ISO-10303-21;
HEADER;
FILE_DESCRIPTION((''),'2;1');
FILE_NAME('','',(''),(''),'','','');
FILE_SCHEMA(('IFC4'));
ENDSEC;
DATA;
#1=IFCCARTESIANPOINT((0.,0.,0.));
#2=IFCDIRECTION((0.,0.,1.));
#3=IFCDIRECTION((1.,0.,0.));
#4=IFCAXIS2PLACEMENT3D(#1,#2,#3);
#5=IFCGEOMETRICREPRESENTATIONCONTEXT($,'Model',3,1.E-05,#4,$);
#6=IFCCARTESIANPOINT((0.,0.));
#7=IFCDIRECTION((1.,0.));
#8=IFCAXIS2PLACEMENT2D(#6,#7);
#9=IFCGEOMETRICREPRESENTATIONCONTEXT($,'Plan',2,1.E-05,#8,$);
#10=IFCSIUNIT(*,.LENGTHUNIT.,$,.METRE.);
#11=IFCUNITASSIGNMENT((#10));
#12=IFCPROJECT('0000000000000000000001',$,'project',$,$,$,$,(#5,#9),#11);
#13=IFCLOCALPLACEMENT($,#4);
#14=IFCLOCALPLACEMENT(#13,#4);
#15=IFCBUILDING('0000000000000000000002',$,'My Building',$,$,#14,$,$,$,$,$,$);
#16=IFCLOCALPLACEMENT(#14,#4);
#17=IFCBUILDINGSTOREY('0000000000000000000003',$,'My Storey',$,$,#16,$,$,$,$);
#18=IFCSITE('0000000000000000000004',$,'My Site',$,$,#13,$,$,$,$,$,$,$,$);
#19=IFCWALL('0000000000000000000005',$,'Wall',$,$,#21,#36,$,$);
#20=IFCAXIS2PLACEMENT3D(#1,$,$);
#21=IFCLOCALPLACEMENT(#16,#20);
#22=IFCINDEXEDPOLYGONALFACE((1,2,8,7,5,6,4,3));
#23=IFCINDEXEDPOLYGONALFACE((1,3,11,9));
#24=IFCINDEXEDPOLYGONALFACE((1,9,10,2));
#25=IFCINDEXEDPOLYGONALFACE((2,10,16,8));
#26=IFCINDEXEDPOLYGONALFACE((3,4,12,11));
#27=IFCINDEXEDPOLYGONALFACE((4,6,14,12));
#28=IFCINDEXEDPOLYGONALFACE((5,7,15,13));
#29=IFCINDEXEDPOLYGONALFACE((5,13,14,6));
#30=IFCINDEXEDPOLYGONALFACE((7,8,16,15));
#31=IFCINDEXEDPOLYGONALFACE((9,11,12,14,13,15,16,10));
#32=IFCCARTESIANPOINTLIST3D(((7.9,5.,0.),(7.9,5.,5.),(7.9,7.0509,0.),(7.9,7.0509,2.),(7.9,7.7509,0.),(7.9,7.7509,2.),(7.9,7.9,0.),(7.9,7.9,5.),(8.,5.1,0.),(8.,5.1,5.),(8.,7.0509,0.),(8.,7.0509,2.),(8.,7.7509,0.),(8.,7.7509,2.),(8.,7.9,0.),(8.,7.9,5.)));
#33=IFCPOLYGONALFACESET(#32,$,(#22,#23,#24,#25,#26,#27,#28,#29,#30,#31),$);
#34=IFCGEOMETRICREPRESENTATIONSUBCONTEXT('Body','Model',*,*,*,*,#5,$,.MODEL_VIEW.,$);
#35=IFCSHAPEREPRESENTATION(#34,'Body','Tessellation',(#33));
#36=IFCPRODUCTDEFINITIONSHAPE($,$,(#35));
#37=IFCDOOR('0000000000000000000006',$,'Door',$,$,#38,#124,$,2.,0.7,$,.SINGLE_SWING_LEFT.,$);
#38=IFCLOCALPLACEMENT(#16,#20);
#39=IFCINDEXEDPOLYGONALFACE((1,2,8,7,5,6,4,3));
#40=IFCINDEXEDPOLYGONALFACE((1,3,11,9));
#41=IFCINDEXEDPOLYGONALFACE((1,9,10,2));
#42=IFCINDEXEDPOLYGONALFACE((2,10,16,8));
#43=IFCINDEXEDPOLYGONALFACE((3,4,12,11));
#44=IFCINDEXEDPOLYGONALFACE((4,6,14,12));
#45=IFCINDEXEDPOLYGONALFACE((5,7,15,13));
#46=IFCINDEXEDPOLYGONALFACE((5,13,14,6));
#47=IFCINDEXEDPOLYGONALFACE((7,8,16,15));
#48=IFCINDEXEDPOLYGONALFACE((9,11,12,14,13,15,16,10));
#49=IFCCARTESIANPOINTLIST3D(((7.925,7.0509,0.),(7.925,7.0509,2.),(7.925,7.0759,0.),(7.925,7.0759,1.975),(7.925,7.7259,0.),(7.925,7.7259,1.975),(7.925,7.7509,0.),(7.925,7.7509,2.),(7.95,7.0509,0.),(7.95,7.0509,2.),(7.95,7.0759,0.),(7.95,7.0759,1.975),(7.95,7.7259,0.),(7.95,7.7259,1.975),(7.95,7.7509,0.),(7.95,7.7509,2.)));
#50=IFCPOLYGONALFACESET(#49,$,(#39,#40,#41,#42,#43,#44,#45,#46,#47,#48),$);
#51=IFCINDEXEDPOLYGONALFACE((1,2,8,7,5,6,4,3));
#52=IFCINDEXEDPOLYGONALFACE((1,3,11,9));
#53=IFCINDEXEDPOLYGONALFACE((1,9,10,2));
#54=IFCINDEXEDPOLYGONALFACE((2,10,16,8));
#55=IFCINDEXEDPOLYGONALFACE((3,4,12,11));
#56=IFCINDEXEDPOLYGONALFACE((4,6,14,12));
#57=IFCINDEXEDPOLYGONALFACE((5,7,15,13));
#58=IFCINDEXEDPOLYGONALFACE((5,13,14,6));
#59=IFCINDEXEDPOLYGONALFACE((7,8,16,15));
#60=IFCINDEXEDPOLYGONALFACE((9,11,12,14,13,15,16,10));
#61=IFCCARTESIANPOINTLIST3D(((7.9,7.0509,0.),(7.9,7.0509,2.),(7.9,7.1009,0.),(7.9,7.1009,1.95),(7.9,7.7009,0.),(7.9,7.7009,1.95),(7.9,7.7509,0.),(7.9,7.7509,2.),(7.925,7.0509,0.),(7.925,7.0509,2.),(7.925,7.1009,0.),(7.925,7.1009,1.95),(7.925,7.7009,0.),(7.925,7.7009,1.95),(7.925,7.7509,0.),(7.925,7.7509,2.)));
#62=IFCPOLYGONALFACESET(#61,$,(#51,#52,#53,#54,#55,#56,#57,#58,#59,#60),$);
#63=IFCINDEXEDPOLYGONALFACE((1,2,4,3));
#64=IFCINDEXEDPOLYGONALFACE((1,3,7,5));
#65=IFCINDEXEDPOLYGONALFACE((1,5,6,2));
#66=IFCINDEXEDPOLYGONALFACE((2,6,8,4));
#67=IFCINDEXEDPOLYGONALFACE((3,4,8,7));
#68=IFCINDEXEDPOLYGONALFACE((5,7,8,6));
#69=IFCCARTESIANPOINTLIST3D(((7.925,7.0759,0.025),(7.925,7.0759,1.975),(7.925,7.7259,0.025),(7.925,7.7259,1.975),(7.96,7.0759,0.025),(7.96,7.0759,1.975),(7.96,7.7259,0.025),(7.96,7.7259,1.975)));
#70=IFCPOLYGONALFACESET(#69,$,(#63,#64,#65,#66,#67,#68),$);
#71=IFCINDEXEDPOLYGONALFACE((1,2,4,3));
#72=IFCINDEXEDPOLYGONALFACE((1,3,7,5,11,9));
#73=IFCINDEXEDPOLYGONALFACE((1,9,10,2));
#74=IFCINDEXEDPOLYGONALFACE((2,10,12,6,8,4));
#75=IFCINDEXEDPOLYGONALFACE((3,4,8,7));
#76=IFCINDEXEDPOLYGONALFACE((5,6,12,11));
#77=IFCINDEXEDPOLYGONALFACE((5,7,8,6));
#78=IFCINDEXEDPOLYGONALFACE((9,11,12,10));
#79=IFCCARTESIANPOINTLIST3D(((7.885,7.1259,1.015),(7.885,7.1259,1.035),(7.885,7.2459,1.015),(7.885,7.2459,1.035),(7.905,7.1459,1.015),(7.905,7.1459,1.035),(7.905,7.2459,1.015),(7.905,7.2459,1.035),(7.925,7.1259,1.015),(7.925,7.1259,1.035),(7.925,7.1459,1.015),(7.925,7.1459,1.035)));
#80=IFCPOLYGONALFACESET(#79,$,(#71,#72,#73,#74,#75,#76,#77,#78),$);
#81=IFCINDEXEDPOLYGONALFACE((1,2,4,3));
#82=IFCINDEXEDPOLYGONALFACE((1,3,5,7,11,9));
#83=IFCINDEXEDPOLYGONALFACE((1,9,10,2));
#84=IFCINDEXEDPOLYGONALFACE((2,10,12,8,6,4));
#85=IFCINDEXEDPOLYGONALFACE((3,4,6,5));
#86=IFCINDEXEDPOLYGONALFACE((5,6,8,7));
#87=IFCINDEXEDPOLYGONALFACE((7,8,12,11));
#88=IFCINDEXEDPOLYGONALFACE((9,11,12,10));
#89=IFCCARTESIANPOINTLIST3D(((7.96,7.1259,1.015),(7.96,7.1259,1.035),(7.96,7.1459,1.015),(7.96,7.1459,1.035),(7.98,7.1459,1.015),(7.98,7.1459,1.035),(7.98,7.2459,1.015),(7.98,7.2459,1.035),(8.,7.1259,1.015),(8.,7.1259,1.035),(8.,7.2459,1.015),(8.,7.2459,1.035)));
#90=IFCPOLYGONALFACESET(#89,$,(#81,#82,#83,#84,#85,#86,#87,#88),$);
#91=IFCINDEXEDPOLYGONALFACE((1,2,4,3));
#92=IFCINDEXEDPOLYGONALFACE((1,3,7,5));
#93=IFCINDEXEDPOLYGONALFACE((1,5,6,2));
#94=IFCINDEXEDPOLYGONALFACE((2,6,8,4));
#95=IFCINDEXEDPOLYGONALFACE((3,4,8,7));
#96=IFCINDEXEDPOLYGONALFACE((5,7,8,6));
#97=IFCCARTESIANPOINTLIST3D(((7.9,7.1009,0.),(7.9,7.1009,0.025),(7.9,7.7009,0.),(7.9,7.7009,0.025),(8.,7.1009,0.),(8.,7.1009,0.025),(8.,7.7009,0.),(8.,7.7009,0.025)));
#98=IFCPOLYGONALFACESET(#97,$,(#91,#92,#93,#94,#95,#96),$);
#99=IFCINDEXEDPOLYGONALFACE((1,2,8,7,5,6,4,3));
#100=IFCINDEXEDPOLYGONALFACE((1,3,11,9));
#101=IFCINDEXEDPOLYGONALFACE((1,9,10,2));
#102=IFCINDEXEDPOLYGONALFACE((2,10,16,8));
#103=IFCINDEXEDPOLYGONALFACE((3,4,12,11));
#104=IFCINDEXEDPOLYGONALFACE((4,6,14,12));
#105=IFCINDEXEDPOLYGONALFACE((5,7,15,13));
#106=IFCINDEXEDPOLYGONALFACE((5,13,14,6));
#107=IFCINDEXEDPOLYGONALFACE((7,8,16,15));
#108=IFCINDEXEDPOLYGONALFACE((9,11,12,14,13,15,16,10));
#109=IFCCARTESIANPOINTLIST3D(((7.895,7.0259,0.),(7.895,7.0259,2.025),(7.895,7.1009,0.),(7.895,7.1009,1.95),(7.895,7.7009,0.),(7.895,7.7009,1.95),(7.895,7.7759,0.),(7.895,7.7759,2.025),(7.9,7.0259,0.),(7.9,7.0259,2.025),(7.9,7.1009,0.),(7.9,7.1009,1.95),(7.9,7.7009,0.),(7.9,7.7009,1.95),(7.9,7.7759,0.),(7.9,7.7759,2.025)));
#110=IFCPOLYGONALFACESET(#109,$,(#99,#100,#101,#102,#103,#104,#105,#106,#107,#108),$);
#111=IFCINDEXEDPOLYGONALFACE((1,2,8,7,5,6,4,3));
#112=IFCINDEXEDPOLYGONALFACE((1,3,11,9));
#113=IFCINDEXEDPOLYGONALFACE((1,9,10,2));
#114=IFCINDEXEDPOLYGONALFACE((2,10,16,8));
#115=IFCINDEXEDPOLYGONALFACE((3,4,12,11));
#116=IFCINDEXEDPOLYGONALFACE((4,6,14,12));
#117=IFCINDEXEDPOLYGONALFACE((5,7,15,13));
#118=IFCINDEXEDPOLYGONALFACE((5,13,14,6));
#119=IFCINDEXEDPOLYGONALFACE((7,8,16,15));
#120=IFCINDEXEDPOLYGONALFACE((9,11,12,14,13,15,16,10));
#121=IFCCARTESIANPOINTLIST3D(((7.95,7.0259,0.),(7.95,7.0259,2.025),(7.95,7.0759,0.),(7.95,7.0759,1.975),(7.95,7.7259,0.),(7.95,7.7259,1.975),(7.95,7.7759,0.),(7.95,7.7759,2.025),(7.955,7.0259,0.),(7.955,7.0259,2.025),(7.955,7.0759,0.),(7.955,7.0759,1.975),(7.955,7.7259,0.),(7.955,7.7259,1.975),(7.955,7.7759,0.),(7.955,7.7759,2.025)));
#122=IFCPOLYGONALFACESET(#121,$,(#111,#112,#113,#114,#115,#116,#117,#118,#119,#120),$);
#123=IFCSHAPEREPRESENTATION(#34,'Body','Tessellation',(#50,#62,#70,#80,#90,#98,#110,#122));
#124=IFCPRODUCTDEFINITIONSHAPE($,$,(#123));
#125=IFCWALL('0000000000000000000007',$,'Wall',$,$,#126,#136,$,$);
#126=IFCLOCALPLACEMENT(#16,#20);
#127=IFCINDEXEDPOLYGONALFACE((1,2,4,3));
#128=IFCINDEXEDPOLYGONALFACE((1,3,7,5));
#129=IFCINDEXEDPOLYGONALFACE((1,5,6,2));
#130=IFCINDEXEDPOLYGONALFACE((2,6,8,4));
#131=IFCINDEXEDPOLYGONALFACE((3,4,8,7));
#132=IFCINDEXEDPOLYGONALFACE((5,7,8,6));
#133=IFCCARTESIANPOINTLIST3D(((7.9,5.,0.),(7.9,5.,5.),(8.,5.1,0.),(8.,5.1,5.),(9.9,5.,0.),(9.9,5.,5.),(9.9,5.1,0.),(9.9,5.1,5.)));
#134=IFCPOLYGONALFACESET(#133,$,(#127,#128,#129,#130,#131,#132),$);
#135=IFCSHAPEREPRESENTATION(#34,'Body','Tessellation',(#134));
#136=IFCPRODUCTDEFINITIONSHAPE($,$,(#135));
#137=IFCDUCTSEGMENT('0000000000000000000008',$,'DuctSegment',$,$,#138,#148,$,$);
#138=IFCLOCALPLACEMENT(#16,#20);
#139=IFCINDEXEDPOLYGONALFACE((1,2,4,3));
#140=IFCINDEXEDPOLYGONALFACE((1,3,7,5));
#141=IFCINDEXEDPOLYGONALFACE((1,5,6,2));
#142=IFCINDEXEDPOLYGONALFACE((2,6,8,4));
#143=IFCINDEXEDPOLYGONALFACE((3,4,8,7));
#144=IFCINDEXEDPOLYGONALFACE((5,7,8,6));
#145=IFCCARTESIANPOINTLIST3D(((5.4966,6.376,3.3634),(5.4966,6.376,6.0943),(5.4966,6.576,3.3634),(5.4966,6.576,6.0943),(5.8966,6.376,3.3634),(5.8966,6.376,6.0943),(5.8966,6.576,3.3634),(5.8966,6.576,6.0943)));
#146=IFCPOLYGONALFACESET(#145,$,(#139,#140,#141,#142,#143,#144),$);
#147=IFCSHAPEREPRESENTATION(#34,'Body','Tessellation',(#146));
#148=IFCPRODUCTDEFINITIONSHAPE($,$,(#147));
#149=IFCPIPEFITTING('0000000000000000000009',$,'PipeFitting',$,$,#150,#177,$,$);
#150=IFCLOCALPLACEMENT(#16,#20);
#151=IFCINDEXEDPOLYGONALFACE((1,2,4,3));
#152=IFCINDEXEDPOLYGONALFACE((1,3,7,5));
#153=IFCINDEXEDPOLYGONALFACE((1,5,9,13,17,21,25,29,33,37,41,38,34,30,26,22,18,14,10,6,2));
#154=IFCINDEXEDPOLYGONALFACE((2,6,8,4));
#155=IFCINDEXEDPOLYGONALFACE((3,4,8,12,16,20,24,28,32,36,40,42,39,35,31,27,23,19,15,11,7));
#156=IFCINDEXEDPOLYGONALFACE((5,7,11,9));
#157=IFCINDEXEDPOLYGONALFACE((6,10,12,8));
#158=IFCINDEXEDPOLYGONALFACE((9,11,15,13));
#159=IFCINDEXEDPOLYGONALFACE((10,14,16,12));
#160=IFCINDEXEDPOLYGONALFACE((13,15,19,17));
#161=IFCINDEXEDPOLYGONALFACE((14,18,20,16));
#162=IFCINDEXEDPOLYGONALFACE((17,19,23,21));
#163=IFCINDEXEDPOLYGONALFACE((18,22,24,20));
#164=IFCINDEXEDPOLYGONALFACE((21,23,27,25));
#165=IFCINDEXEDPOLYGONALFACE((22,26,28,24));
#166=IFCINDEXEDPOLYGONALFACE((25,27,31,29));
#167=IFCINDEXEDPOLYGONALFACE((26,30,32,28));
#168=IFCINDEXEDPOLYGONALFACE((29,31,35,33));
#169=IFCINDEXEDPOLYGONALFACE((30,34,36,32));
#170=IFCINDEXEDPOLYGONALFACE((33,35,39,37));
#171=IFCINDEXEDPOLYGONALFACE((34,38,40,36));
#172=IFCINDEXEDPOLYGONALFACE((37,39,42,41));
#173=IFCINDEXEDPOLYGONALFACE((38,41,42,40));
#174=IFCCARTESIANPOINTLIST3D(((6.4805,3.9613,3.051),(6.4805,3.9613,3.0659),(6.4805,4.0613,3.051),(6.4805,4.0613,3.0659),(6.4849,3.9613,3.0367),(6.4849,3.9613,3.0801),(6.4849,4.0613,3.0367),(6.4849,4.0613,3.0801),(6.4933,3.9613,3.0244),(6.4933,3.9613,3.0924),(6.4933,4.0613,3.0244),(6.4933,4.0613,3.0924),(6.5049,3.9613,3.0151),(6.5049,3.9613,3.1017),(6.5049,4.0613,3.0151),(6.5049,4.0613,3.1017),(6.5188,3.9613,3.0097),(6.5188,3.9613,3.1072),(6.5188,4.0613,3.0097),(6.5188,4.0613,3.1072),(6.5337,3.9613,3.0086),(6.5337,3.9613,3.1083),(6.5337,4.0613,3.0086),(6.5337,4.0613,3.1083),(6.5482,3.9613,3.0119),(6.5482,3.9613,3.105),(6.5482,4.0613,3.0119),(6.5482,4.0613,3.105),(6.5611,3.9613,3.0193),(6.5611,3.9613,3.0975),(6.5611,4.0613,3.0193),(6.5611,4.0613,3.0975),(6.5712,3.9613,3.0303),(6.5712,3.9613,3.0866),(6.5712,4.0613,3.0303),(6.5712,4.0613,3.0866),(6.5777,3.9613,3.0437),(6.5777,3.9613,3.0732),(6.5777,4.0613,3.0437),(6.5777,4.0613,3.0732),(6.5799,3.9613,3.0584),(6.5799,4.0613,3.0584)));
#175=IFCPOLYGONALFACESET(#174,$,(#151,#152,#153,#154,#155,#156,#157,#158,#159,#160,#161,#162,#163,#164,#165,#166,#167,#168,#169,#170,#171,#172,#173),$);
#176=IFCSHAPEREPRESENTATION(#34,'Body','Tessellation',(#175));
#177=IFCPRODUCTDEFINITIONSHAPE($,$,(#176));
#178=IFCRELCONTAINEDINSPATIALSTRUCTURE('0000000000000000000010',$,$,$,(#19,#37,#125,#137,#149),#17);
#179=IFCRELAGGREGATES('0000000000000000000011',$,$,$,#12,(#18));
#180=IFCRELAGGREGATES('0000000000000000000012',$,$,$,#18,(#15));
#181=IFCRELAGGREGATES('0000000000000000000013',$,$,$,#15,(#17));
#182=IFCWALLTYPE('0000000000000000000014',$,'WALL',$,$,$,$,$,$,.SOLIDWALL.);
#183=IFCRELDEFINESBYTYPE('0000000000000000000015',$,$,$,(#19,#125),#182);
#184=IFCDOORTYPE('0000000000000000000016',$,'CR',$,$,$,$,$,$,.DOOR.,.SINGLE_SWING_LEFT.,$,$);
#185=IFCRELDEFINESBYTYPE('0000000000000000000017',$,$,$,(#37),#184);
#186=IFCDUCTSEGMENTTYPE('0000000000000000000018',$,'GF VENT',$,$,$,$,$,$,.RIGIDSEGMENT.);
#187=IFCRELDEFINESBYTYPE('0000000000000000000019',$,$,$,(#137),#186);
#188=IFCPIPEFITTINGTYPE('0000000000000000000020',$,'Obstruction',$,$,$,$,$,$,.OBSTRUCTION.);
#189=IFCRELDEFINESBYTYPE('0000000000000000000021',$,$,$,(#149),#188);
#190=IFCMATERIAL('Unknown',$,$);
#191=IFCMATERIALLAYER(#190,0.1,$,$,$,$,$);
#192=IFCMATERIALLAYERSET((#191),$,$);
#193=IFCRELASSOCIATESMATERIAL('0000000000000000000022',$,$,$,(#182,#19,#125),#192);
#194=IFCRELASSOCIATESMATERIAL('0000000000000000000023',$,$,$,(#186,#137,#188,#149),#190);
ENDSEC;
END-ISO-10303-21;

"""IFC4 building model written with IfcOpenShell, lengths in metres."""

from ifc_helpers import new_model, entity, si_unit, frame, origin_with_axes, origin_2d_with_axis, place, context, subcontext, project, spatial, line, indexed_curve, rectangle, circle, outline, extrude, shape, source, transform, mapped, material, layer, layer_set, layer_usage, material_profile, profile_set, profile_usage, type_object, type_shapes, element, fill, save


model = new_model("IFC4")

# Units and contexts
model_context = context("Model", 3, precision=1e-05, world=origin_with_axes())
plan_context = context("Plan", 2, precision=1e-05, world=origin_2d_with_axis())
body_context_1 = subcontext(model_context, "Body", "Model", "MODEL_VIEW")
body_context_2 = subcontext(plan_context, "Body", "Plan", "PLAN_VIEW")
ifc_project = project(units=[si_unit("LENGTHUNIT", "METRE")], contexts=[model_context, plan_context])

# Site, building, storey
site_placement = place(None, origin_with_axes())
site = spatial("IfcSite", under=ifc_project, at=site_placement, Name="My Site")
building_placement = place(site_placement, origin_with_axes())
building = spatial("IfcBuilding", under=site, at=building_placement, Name="My Building")
storey_placement = place(building_placement, origin_with_axes())
storey = spatial("IfcBuildingStorey", under=building, at=storey_placement, Name="My Storey")

# Shared definitions
ifc_material = material(Name="Unknown")

# Shared definitions
ifc_layer = layer(ifc_material, 0.1)
ifc_layer_set = layer_set([ifc_layer])
wall_type = type_object("IfcWallType", Name="WALL", PredefinedType="SOLIDWALL", material=ifc_layer_set)

# Wall, opening, door
ifc_layer_usage_1 = layer_usage(ifc_layer_set, "AXIS2", "POSITIVE", 0.0)
wall_1_placement = place(storey_placement, frame((8.0, 5.0, 0.0), z_axis=(0.0, 0.0, 1.0), x_axis=(0.0, 1.0, 0.0)))
wall_1 = element("IfcWall", 1, at=wall_1_placement, inside=storey, type_object=wall_type, material=ifc_layer_usage_1, Name="Wall", context=body_context_1, shape_type="SweptSolid", body=[
    extrude(outline(indexed_curve([(0.1, 0.0), (0.0, 0.1), (2.9, 0.1), (2.9, 0.0)], segments=[line(1, 2, 3, 4, 1)])), origin_with_axes(), (0.0, 0.0, 1.0), 5.0),
])
shared_shape_1 = source(origin_with_axes(), body_context_1, "Body", "SweptSolid", [
    extrude(outline(indexed_curve([(0.0, 0.0), (0.7, 0.0), (0.7, 2.0), (0.0, 2.0)], segments=[line(1, 2, 3, 4, 1)])), frame((0.0, -0.6, 0.0), z_axis=(0.0, -1.0, 0.0), x_axis=(1.0, 0.0, 0.0)), (0.0, 0.0, -1.0), 1.2),
])
opening_1_placement = place(wall_1_placement, frame((2.7509, 0.1, 0.0), z_axis=(0.0, 0.0, 1.0), x_axis=(-1.0, 0.0, 0.0)))
opening_1 = element("IfcOpeningElement", 2, at=opening_1_placement, cuts=wall_1, PredefinedType="OPENING", context=body_context_1, shape_type="MappedRepresentation", body=[
    mapped(shared_shape_1, transform((0.0, 0.0, 0.0), x_axis=(1.0, 0.0, 0.0), y_axis=(0.0, 1.0, 0.0), z_axis=(0.0, 0.0, 1.0), scale=1.0)),
])
door_type = type_object("IfcDoorType", Name="CR", OperationType="SINGLE_SWING_LEFT", PredefinedType="DOOR")
shared_shape_2 = source(origin_with_axes(), body_context_1, "Body", "SweptSolid", [
    extrude(outline(indexed_curve([(0.0, 0.0), (0.0, 2.0), (0.7, 2.0), (0.7, 0.0), (0.675, 0.0), (0.675, 1.975), (0.025, 1.975), (0.025, 0.0)], segments=[line(1, 2, 3, 4, 5, 6, 7, 8, 1)])), frame((0.0, 0.025, 0.0), z_axis=(0.0, -1.0, 0.0), x_axis=(1.0, 0.0, 0.0)), (0.0, 0.0, -1.0), 0.025),
    extrude(outline(indexed_curve([(0.0, 0.0), (0.0, 2.0), (0.7, 2.0), (0.7, 0.0), (0.65, 0.0), (0.65, 1.95), (0.05, 1.95), (0.05, 0.0)], segments=[line(1, 2, 3, 4, 5, 6, 7, 8, 1)])), frame((0.0, 0.0, 0.0), z_axis=(0.0, -1.0, 0.0), x_axis=(1.0, 0.0, 0.0)), (0.0, 0.0, -1.0), 0.025),
    extrude(outline(indexed_curve([(0.0, 0.0), (0.65, 0.0), (0.65, 0.035), (0.0, 0.035)], segments=[line(1, 2, 3, 4, 1)])), frame((0.025, 0.025, 0.025), z_axis=(0.0, 0.0, 1.0), x_axis=(1.0, 0.0, 0.0)), (0.0, 0.0, 1.0), 1.95),
    extrude(outline(indexed_curve([(0.0, 0.0), (0.0, -0.04), (-0.12, -0.04), (-0.12, -0.02), (-0.02, -0.02), (-0.02, 0.0)], segments=[line(1, 2, 3, 4, 5, 6, 1)])), frame((0.625, 0.025, 1.015), z_axis=(0.0, 0.0, 1.0), x_axis=(1.0, 0.0, 0.0)), (0.0, 0.0, 1.0), 0.02),
    extrude(outline(indexed_curve([(0.0, 0.0), (0.0, 0.04), (-0.12, 0.04), (-0.12, 0.02), (-0.02, 0.02), (-0.02, 0.0)], segments=[line(1, 2, 3, 4, 5, 6, 1)])), frame((0.625, 0.06, 1.015), z_axis=(0.0, 0.0, 1.0), x_axis=(1.0, 0.0, 0.0)), (0.0, 0.0, 1.0), 0.02),
    extrude(outline(indexed_curve([(0.0, 0.0), (0.6, 0.0), (0.6, 0.1), (0.0, 0.1)], segments=[line(1, 2, 3, 4, 1)])), frame((0.05, 0.0, 0.0), z_axis=(0.0, 0.0, 1.0), x_axis=(1.0, 0.0, 0.0)), (0.0, 0.0, 1.0), 0.025),
    extrude(outline(indexed_curve([(0.0, 0.0), (0.0, 2.025), (0.75, 2.025), (0.75, 0.0), (0.675, 0.0), (0.675, 1.95), (0.075, 1.95), (0.075, 0.0)], segments=[line(1, 2, 3, 4, 5, 6, 7, 8, 1)])), frame((-0.025, -0.005, 0.0), z_axis=(0.0, -1.0, 0.0), x_axis=(1.0, 0.0, 0.0)), (0.0, 0.0, -1.0), 0.005),
    extrude(outline(indexed_curve([(0.0, 0.0), (0.0, 2.025), (0.75, 2.025), (0.75, 0.0), (0.7, 0.0), (0.7, 1.975), (0.05, 1.975), (0.05, 0.0)], segments=[line(1, 2, 3, 4, 5, 6, 7, 8, 1)])), frame((-0.025, 0.05, 0.0), z_axis=(0.0, -1.0, 0.0), x_axis=(1.0, 0.0, 0.0)), (0.0, 0.0, -1.0), 0.005),
])
shared_shape_3 = source(origin_with_axes(), body_context_2, "Body", "Curve2D", [
    entity("IfcIndexedPolyCurve", entity("IfcCartesianPointList2D", [[0.0, 0.0], [0.0, 0.05], [0.025, 0.05], [0.025, 0.025], [0.05, 0.025], [0.05, 0.0]]), [entity("IfcLineIndex", [1, 2, 3, 4, 5, 6, 1])]),
    entity("IfcIndexedPolyCurve", entity("IfcCartesianPointList2D", [[0.7, 0.0], [0.7, 0.05], [0.675, 0.05], [0.675, 0.025], [0.65, 0.025], [0.65, 0.0]]), [entity("IfcLineIndex", [1, 2, 3, 4, 5, 6, 1])]),
    entity("IfcTrimmedCurve", entity("IfcEllipse", entity("IfcAxis2Placement2D", entity("IfcCartesianPoint", [0.06, 0.05]), entity("IfcDirection", [1.0, 0.0])), 0.615, 0.65), [entity("IfcCartesianPoint", [0.675, 0.05])], [entity("IfcCartesianPoint", [0.06, 0.7])], True, "CARTESIAN"),
    entity("IfcIndexedPolyCurve", entity("IfcCartesianPointList2D", [[0.025, 0.05], [0.06, 0.05], [0.06, 0.7], [0.025, 0.7]]), [entity("IfcLineIndex", [1, 2, 3, 4, 1])]),
])
type_shapes(door_type, [shared_shape_2, shared_shape_3])
door_placement = place(opening_1_placement, origin_with_axes())
door = element("IfcDoor", 3, at=door_placement, inside=storey, type_object=door_type, Name="Door", OperationType="SINGLE_SWING_LEFT", OverallHeight=2.0, OverallWidth=0.7, shapes=[
    shape(body_context_1, "Body", "MappedRepresentation", [mapped(shared_shape_2, transform((0.0, 0.0, 0.0), x_axis=(1.0, 0.0, 0.0), y_axis=(0.0, 1.0, 0.0), z_axis=(0.0, 0.0, 1.0), scale=1.0))]),
    shape(body_context_2, "Body", "MappedRepresentation", [mapped(shared_shape_3, transform((0.0, 0.0, 0.0), x_axis=(1.0, 0.0, 0.0), y_axis=(0.0, 1.0, 0.0), z_axis=(0.0, 0.0, 1.0), scale=1.0))]),
])
fill(opening_1, door)

# Wall
ifc_layer_usage_2 = layer_usage(ifc_layer_set, "AXIS2", "POSITIVE", 0.0)
wall_2_placement = place(storey_placement, frame((8.0, 5.0, 0.0), z_axis=(0.0, 0.0, 1.0), x_axis=(1.0, 0.0, 0.0)))
element("IfcWall", 4, at=wall_2_placement, inside=storey, type_object=wall_type, material=ifc_layer_usage_2, Name="Wall", context=body_context_1, shape_type="SweptSolid", body=[
    extrude(outline(indexed_curve([(-0.1, 0.0), (0.0, 0.1), (1.9, 0.1), (1.9, 0.0)], segments=[line(1, 2, 3, 4, 1)])), origin_with_axes(), (0.0, 0.0, 1.0), 5.0),
])

# Duct segment
ifc_material_profile_1 = material_profile(ifc_material, rectangle(XDim=0.4, YDim=0.2))
ifc_profile_set_1 = profile_set([ifc_material_profile_1])
ifc_profile_usage_1 = profile_usage(ifc_profile_set_1, cardinal=5)
duct_segment_type = type_object("IfcDuctSegmentType", Name="GF VENT", PredefinedType="RIGIDSEGMENT", material=ifc_profile_set_1)
duct_segment_placement = place(storey_placement, frame((5.6966, 6.476, 3.3634), z_axis=(0.0, 0.0, 1.0), x_axis=(-1.0, 0.0, 0.0)))
element("IfcDuctSegment", 5, at=duct_segment_placement, inside=storey, type_object=duct_segment_type, material=ifc_profile_usage_1, Name="DuctSegment", context=body_context_1, shape_type="SweptSolid", body=[
    extrude(rectangle(XDim=0.4, YDim=0.2), origin_with_axes(), (0.0, 0.0, 1.0), 2.731),
])

# Pipe fitting
ifc_material_profile_2 = material_profile(ifc_material, circle(Radius=0.05))
ifc_profile_set_2 = profile_set([ifc_material_profile_2])
ifc_profile_usage_2 = profile_usage(ifc_profile_set_2, cardinal=5)
pipe_fitting_type = type_object("IfcPipeFittingType", Name="Obstruction", PredefinedType="OBSTRUCTION", material=ifc_profile_set_2)
pipe_fitting_1_placement = place(storey_placement, frame((6.5299, 4.0613, 3.0584), z_axis=(0.0, -1.0, 0.0), x_axis=(1.0, 0.0, 0.0)))
element("IfcPipeFitting", 6, at=pipe_fitting_1_placement, inside=storey, type_object=pipe_fitting_type, material=ifc_profile_usage_2, Name="PipeFitting", context=body_context_1, shape_type="SweptSolid", body=[
    extrude(circle(Radius=0.05), origin_with_axes(), (0.0, 0.0, 1.0), 0.1),
])

save(model, "model.ifc")
